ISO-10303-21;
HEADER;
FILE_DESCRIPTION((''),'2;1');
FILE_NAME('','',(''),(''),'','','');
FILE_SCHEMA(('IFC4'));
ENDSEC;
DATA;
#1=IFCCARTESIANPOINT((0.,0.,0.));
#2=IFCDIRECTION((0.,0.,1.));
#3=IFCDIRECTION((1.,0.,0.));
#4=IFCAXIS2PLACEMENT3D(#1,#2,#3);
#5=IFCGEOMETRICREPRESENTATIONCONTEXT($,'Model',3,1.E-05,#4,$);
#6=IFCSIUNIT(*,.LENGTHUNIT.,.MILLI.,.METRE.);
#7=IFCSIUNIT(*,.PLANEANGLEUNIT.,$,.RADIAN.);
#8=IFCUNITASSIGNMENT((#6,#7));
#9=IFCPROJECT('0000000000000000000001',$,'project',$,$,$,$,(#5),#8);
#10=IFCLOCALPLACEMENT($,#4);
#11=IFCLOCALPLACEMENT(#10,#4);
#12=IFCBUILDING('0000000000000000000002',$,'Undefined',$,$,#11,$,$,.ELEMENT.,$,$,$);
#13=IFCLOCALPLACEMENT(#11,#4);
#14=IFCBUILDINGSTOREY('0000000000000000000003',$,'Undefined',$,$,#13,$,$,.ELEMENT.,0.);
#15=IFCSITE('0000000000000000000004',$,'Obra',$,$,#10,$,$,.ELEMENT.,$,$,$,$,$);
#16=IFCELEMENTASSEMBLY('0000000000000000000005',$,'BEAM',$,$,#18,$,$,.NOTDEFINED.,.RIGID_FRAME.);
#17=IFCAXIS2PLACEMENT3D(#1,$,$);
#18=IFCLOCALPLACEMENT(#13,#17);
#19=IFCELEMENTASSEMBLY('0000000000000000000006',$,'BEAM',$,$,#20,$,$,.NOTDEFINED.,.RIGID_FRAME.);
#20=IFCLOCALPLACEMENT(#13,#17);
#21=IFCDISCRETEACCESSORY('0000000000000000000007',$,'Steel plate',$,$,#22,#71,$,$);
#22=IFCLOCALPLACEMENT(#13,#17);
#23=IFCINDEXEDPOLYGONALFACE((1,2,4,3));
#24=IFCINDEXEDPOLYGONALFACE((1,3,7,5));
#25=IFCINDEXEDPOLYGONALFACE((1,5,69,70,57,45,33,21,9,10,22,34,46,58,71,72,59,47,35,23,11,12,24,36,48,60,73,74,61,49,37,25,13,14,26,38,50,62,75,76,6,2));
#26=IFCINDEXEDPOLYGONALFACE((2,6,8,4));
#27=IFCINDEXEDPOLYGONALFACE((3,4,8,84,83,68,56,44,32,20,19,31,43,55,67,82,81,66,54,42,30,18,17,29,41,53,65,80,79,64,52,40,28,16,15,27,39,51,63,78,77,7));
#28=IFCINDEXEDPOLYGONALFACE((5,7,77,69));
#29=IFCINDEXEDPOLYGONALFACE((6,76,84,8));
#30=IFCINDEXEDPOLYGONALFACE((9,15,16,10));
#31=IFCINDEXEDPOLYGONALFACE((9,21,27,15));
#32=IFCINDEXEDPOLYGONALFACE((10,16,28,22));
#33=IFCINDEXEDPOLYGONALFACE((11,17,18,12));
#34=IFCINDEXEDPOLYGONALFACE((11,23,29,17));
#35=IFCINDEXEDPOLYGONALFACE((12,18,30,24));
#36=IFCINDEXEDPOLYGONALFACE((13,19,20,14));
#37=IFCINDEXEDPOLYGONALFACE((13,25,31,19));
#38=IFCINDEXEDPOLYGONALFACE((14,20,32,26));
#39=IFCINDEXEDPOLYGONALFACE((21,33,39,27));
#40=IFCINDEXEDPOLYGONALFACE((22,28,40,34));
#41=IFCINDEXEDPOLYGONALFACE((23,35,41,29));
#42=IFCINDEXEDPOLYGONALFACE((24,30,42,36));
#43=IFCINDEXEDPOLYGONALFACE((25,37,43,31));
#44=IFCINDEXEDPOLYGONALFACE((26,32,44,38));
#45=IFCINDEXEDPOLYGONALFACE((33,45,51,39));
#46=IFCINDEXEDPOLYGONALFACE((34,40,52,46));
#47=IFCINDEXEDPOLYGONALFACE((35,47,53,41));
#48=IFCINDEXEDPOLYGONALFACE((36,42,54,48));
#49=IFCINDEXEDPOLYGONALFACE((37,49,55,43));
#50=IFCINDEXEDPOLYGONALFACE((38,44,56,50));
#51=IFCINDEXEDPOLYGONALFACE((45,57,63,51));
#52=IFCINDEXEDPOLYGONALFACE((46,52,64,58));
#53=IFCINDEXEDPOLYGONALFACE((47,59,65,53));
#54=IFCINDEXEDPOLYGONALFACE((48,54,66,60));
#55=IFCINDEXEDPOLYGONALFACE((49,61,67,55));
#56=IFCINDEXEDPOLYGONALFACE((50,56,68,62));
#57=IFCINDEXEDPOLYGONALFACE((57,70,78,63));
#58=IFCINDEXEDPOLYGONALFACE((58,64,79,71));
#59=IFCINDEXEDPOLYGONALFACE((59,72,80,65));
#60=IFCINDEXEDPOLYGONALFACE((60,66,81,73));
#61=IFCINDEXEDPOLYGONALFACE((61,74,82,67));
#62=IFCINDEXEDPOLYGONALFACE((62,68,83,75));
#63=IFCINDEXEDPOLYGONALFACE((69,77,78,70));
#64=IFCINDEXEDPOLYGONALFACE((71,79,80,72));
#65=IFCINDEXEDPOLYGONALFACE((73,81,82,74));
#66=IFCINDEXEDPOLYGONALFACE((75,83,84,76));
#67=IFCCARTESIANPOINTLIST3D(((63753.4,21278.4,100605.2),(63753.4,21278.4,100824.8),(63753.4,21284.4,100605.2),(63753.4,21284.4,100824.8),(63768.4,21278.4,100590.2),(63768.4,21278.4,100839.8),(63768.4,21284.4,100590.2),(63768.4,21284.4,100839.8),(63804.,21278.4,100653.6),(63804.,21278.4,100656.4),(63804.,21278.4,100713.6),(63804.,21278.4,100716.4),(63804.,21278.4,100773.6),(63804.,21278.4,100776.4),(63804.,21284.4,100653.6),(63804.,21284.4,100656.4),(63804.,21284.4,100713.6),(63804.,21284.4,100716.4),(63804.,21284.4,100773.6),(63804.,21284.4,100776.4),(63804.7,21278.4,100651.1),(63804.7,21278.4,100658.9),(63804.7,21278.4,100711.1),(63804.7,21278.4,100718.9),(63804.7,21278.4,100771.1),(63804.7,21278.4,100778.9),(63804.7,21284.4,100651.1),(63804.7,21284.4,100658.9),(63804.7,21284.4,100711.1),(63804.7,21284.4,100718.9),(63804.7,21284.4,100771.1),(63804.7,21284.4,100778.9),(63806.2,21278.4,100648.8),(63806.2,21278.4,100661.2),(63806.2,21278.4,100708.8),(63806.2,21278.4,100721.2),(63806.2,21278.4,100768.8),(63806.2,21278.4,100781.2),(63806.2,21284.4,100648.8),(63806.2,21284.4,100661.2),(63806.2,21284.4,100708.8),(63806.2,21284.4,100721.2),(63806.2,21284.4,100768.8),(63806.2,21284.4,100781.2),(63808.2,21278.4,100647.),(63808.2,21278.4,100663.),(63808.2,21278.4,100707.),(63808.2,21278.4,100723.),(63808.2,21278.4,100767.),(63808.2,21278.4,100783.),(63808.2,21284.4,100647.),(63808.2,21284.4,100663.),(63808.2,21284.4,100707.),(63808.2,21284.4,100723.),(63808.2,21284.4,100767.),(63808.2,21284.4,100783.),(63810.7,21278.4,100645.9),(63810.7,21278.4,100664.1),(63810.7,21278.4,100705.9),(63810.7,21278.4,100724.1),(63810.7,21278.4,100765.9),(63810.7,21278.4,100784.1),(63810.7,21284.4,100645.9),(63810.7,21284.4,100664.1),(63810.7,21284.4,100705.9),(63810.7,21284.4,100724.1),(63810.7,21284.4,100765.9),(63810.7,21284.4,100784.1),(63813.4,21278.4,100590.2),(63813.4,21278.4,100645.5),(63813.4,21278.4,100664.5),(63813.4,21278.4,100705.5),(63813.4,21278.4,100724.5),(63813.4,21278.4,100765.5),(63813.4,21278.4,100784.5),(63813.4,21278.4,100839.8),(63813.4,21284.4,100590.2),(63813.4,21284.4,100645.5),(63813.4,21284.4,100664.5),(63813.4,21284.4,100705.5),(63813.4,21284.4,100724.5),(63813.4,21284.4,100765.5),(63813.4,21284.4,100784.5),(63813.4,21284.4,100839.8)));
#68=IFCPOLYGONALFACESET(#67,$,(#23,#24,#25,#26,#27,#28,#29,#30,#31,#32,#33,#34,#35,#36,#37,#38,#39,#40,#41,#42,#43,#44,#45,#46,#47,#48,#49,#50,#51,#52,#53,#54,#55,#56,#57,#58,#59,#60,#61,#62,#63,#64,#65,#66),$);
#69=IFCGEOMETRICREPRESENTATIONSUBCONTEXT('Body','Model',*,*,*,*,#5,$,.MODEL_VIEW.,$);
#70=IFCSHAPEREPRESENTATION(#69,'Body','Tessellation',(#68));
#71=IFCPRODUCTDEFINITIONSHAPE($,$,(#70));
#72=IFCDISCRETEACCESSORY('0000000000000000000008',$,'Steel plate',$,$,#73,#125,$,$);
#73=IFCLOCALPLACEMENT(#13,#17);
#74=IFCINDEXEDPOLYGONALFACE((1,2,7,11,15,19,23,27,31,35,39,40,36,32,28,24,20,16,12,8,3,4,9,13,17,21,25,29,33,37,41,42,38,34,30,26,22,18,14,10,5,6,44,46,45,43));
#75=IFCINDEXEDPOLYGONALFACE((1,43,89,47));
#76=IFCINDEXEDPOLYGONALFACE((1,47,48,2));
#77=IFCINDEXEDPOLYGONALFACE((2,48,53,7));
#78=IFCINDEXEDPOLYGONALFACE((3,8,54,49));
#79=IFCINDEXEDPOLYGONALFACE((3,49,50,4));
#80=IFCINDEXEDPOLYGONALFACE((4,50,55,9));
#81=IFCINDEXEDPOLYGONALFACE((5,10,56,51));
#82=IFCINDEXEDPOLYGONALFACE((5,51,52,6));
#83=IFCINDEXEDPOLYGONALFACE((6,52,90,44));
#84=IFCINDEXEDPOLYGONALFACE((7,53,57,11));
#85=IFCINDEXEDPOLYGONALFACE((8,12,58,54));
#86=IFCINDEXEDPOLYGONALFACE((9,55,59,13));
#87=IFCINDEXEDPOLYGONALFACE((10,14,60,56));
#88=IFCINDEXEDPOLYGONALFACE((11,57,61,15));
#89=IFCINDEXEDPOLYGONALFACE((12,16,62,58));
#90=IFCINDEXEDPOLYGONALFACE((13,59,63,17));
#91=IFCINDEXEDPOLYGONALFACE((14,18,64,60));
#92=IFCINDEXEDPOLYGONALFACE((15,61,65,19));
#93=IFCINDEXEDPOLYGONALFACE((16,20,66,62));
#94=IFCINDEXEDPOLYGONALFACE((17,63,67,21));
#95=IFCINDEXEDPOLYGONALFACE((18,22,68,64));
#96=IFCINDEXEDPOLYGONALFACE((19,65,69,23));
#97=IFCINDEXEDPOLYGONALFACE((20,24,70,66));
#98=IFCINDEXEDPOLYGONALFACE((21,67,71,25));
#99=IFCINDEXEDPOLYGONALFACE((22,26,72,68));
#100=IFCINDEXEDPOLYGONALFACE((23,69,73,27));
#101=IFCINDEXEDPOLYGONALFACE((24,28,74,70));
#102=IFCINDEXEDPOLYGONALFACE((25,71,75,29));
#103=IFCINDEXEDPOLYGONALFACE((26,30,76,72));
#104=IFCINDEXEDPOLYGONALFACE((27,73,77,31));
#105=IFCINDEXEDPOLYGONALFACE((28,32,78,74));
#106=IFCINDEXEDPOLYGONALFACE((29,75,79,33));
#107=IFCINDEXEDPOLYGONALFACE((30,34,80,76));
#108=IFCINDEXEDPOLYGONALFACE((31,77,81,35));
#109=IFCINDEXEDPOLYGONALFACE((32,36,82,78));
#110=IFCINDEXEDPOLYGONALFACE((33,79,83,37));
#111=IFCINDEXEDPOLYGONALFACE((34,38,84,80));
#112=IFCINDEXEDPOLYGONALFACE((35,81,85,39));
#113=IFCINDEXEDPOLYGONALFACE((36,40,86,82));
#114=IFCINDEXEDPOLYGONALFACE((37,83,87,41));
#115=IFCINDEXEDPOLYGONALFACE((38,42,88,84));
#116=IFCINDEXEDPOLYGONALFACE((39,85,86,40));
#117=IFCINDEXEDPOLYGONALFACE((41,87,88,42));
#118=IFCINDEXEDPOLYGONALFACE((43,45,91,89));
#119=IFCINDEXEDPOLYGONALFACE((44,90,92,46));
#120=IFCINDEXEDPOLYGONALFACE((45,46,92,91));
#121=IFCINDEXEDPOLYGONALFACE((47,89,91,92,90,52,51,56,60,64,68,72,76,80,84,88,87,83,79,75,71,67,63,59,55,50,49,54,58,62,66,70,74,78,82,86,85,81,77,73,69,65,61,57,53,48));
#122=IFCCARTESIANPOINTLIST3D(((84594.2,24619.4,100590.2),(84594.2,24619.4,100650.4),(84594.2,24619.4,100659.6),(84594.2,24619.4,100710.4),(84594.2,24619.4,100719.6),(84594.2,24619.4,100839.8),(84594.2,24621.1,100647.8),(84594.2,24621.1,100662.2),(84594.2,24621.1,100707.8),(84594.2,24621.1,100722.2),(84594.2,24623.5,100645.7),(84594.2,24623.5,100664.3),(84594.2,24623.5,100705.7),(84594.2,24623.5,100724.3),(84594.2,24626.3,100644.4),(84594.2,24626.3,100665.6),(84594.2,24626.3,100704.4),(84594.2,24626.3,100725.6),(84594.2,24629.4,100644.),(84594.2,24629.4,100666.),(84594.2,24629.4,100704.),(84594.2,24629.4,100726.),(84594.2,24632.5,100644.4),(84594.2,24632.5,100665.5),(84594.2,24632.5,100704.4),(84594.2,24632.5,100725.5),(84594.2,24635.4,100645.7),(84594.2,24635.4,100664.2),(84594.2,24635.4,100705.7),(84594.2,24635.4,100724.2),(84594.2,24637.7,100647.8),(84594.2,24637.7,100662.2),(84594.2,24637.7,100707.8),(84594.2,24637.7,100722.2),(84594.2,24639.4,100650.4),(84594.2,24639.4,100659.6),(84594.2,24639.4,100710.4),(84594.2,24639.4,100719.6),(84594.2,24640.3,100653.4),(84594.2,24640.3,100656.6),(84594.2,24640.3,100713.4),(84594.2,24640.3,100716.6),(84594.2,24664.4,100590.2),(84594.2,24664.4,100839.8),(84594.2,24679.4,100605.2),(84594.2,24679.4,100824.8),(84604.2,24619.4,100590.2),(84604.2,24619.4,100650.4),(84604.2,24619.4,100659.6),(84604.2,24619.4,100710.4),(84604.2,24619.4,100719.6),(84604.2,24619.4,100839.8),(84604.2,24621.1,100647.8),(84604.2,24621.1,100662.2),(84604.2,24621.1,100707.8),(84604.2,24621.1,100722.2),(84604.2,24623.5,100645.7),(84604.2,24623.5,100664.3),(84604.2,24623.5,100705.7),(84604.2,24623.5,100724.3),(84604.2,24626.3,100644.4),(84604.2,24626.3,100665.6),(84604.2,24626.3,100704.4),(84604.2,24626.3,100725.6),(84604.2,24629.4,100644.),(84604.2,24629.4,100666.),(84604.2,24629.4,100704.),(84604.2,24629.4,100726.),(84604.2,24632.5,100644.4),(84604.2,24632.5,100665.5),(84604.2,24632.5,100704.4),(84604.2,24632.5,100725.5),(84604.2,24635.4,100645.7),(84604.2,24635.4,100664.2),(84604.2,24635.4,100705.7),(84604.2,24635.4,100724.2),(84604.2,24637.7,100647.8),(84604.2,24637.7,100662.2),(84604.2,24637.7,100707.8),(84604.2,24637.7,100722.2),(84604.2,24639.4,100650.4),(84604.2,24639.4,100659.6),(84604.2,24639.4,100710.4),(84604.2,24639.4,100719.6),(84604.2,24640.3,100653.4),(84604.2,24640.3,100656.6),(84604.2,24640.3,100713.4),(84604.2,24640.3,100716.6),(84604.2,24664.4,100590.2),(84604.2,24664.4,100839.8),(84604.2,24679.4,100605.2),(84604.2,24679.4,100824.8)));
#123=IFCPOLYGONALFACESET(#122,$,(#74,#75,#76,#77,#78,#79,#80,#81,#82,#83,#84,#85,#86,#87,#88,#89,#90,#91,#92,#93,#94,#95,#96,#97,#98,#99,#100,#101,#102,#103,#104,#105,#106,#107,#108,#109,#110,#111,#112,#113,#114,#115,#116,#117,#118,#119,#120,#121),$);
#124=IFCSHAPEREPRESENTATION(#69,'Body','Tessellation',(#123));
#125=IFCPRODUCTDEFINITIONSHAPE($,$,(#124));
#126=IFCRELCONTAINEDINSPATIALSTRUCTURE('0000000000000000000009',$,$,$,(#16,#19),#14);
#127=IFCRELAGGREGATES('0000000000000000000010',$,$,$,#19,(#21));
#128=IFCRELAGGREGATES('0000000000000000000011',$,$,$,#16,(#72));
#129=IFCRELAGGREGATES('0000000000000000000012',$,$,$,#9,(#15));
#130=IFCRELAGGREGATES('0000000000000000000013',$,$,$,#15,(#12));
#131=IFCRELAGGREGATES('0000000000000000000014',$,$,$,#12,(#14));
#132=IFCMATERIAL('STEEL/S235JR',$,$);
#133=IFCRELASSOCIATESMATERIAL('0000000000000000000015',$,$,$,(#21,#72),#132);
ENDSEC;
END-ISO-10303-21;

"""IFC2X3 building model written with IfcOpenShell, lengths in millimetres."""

from ifc_helpers import new_model, si_unit, frame, origin_with_axes, origin_2d_with_axis, place, context, subcontext, project, spatial, polyline, circle, outline, extrude, source, transform, mapped, material, element, aggregate, save


model = new_model("IFC2X3")

# Units and contexts
model_context = context("Model", 3, precision=1e-05, world=origin_with_axes())
body_context = subcontext(model_context, "Body", "Model", "MODEL_VIEW")
ifc_project = project(units=[si_unit("LENGTHUNIT", "METRE", prefix="MILLI"), si_unit("PLANEANGLEUNIT", "RADIAN")], contexts=[model_context])

# Site, building, storey
site_placement = place(None, origin_with_axes())
site = spatial("IfcSite", under=ifc_project, at=site_placement, Name="Obra", CompositionType="ELEMENT")
building_placement = place(site_placement, origin_with_axes())
building = spatial("IfcBuilding", under=site, at=building_placement, Name="Undefined", CompositionType="ELEMENT")
storey_placement = place(building_placement, origin_with_axes())
storey = spatial("IfcBuildingStorey", under=building, at=storey_placement, Name="Undefined", CompositionType="ELEMENT", Elevation=0.0)

# Element assembly
assembly_1_placement = place(storey_placement, origin_with_axes())
assembly_1 = element("IfcElementAssembly", 1, at=assembly_1_placement, inside=storey, Name="BEAM", AssemblyPlace="NOTDEFINED", PredefinedType="RIGID_FRAME")
ifc_material = material(Name="STEEL/S235JR")

# Element assembly, discrete accessory, opening
shared_shape_1 = source(origin_with_axes(), body_context, "Body", "SweptSolid", [
    extrude(circle(Radius=9.5, at=origin_2d_with_axis()), frame((0.0, -9.4, 0.0), z_axis=(0.0, 1.0, 0.0), x_axis=(1.0, 0.0, 0.0)), (0.0, 0.0, 1.0), 6.2),
])
assembly_2_placement = place(storey_placement, origin_with_axes())
assembly_2 = element("IfcElementAssembly", 2, at=assembly_2_placement, inside=storey, Name="BEAM", AssemblyPlace="NOTDEFINED", PredefinedType="RIGID_FRAME")
discrete_accessory_1_placement = place(assembly_2_placement, frame((63813.4, 21281.4, 100590.2), z_axis=(0.0, 1.0, 0.0), x_axis=(-1.0, 0.0, 0.0)))
discrete_accessory_1 = element("IfcDiscreteAccessory", 3, at=discrete_accessory_1_placement, material=ifc_material, Name="Steel plate", context=body_context, shape_type="SweptSolid", body=[
    extrude(outline(polyline([(0.0, 0.0), (45.0, 0.0), (60.0, 15.0), (60.0, 234.6), (45.0, 249.6), (0.0, 249.6), (0.0, 0.0)])), frame((0.0, 0.0, -3.0), z_axis=(0.0, 0.0, 1.0), x_axis=(1.0, 0.0, 0.0)), (0.0, 0.0, 1.0), 6.0),
])
opening_1_placement = place(assembly_2_placement, frame((63763.4, 21287.7, 100850.0), z_axis=(1.0, 0.0, 0.0), x_axis=(0.0, 0.0, -1.0)))
element("IfcOpeningElement", 4, at=opening_1_placement, cuts=discrete_accessory_1, ObjectType="Opening", context=body_context, shape_type="MappedRepresentation", body=[
    mapped(shared_shape_1, transform((75.0, 0.0, 50.0))),
    mapped(shared_shape_1, transform((135.0, 0.0, 50.0))),
    mapped(shared_shape_1, transform((195.0, 0.0, 50.0))),
])
aggregate(assembly_2, [discrete_accessory_1])

# Discrete accessory, opening
discrete_accessory_2_placement = place(assembly_1_placement, frame((84599.2, 24619.4, 100590.2), z_axis=(1.0, 0.000001, 0.0), x_axis=(-0.000002, 1.0, 0.0)))
discrete_accessory_2 = element("IfcDiscreteAccessory", 5, at=discrete_accessory_2_placement, material=ifc_material, Name="Steel plate", context=body_context, shape_type="SweptSolid", body=[
    extrude(outline(polyline([(0.0, 0.0), (45.0, 0.0), (60.0, 15.0), (60.0, 234.6), (45.0, 249.6), (0.0, 249.6), (0.0, 0.0)])), frame((0.0, 0.0, -5.0), z_axis=(0.0, 0.0, 1.0), x_axis=(1.0, 0.0, 0.0)), (0.0, 0.0, 1.0), 10.0),
])
shared_shape_2 = source(origin_with_axes(), body_context, "Body", "SweptSolid", [
    extrude(circle(Radius=11.0, at=origin_2d_with_axis()), frame((0.0, -13.9, 0.0), z_axis=(0.0, 1.0, 0.0), x_axis=(1.0, 0.0, 0.0)), (0.0, 0.0, 1.0), 10.2),
])
opening_2_placement = place(assembly_1_placement, frame((84607.9, 24669.4, 100850.0), z_axis=(0.000002, -1.0, 0.0), x_axis=(0.0, 0.0, -1.0)))
element("IfcOpeningElement", 6, at=opening_2_placement, cuts=discrete_accessory_2, ObjectType="Opening", context=body_context, shape_type="MappedRepresentation", body=[
    mapped(shared_shape_2, transform((135.0, 0.0, 40.0))),
    mapped(shared_shape_2, transform((195.0, 0.0, 40.0))),
])
aggregate(assembly_1, [discrete_accessory_2])

save(model, "model.ifc")
